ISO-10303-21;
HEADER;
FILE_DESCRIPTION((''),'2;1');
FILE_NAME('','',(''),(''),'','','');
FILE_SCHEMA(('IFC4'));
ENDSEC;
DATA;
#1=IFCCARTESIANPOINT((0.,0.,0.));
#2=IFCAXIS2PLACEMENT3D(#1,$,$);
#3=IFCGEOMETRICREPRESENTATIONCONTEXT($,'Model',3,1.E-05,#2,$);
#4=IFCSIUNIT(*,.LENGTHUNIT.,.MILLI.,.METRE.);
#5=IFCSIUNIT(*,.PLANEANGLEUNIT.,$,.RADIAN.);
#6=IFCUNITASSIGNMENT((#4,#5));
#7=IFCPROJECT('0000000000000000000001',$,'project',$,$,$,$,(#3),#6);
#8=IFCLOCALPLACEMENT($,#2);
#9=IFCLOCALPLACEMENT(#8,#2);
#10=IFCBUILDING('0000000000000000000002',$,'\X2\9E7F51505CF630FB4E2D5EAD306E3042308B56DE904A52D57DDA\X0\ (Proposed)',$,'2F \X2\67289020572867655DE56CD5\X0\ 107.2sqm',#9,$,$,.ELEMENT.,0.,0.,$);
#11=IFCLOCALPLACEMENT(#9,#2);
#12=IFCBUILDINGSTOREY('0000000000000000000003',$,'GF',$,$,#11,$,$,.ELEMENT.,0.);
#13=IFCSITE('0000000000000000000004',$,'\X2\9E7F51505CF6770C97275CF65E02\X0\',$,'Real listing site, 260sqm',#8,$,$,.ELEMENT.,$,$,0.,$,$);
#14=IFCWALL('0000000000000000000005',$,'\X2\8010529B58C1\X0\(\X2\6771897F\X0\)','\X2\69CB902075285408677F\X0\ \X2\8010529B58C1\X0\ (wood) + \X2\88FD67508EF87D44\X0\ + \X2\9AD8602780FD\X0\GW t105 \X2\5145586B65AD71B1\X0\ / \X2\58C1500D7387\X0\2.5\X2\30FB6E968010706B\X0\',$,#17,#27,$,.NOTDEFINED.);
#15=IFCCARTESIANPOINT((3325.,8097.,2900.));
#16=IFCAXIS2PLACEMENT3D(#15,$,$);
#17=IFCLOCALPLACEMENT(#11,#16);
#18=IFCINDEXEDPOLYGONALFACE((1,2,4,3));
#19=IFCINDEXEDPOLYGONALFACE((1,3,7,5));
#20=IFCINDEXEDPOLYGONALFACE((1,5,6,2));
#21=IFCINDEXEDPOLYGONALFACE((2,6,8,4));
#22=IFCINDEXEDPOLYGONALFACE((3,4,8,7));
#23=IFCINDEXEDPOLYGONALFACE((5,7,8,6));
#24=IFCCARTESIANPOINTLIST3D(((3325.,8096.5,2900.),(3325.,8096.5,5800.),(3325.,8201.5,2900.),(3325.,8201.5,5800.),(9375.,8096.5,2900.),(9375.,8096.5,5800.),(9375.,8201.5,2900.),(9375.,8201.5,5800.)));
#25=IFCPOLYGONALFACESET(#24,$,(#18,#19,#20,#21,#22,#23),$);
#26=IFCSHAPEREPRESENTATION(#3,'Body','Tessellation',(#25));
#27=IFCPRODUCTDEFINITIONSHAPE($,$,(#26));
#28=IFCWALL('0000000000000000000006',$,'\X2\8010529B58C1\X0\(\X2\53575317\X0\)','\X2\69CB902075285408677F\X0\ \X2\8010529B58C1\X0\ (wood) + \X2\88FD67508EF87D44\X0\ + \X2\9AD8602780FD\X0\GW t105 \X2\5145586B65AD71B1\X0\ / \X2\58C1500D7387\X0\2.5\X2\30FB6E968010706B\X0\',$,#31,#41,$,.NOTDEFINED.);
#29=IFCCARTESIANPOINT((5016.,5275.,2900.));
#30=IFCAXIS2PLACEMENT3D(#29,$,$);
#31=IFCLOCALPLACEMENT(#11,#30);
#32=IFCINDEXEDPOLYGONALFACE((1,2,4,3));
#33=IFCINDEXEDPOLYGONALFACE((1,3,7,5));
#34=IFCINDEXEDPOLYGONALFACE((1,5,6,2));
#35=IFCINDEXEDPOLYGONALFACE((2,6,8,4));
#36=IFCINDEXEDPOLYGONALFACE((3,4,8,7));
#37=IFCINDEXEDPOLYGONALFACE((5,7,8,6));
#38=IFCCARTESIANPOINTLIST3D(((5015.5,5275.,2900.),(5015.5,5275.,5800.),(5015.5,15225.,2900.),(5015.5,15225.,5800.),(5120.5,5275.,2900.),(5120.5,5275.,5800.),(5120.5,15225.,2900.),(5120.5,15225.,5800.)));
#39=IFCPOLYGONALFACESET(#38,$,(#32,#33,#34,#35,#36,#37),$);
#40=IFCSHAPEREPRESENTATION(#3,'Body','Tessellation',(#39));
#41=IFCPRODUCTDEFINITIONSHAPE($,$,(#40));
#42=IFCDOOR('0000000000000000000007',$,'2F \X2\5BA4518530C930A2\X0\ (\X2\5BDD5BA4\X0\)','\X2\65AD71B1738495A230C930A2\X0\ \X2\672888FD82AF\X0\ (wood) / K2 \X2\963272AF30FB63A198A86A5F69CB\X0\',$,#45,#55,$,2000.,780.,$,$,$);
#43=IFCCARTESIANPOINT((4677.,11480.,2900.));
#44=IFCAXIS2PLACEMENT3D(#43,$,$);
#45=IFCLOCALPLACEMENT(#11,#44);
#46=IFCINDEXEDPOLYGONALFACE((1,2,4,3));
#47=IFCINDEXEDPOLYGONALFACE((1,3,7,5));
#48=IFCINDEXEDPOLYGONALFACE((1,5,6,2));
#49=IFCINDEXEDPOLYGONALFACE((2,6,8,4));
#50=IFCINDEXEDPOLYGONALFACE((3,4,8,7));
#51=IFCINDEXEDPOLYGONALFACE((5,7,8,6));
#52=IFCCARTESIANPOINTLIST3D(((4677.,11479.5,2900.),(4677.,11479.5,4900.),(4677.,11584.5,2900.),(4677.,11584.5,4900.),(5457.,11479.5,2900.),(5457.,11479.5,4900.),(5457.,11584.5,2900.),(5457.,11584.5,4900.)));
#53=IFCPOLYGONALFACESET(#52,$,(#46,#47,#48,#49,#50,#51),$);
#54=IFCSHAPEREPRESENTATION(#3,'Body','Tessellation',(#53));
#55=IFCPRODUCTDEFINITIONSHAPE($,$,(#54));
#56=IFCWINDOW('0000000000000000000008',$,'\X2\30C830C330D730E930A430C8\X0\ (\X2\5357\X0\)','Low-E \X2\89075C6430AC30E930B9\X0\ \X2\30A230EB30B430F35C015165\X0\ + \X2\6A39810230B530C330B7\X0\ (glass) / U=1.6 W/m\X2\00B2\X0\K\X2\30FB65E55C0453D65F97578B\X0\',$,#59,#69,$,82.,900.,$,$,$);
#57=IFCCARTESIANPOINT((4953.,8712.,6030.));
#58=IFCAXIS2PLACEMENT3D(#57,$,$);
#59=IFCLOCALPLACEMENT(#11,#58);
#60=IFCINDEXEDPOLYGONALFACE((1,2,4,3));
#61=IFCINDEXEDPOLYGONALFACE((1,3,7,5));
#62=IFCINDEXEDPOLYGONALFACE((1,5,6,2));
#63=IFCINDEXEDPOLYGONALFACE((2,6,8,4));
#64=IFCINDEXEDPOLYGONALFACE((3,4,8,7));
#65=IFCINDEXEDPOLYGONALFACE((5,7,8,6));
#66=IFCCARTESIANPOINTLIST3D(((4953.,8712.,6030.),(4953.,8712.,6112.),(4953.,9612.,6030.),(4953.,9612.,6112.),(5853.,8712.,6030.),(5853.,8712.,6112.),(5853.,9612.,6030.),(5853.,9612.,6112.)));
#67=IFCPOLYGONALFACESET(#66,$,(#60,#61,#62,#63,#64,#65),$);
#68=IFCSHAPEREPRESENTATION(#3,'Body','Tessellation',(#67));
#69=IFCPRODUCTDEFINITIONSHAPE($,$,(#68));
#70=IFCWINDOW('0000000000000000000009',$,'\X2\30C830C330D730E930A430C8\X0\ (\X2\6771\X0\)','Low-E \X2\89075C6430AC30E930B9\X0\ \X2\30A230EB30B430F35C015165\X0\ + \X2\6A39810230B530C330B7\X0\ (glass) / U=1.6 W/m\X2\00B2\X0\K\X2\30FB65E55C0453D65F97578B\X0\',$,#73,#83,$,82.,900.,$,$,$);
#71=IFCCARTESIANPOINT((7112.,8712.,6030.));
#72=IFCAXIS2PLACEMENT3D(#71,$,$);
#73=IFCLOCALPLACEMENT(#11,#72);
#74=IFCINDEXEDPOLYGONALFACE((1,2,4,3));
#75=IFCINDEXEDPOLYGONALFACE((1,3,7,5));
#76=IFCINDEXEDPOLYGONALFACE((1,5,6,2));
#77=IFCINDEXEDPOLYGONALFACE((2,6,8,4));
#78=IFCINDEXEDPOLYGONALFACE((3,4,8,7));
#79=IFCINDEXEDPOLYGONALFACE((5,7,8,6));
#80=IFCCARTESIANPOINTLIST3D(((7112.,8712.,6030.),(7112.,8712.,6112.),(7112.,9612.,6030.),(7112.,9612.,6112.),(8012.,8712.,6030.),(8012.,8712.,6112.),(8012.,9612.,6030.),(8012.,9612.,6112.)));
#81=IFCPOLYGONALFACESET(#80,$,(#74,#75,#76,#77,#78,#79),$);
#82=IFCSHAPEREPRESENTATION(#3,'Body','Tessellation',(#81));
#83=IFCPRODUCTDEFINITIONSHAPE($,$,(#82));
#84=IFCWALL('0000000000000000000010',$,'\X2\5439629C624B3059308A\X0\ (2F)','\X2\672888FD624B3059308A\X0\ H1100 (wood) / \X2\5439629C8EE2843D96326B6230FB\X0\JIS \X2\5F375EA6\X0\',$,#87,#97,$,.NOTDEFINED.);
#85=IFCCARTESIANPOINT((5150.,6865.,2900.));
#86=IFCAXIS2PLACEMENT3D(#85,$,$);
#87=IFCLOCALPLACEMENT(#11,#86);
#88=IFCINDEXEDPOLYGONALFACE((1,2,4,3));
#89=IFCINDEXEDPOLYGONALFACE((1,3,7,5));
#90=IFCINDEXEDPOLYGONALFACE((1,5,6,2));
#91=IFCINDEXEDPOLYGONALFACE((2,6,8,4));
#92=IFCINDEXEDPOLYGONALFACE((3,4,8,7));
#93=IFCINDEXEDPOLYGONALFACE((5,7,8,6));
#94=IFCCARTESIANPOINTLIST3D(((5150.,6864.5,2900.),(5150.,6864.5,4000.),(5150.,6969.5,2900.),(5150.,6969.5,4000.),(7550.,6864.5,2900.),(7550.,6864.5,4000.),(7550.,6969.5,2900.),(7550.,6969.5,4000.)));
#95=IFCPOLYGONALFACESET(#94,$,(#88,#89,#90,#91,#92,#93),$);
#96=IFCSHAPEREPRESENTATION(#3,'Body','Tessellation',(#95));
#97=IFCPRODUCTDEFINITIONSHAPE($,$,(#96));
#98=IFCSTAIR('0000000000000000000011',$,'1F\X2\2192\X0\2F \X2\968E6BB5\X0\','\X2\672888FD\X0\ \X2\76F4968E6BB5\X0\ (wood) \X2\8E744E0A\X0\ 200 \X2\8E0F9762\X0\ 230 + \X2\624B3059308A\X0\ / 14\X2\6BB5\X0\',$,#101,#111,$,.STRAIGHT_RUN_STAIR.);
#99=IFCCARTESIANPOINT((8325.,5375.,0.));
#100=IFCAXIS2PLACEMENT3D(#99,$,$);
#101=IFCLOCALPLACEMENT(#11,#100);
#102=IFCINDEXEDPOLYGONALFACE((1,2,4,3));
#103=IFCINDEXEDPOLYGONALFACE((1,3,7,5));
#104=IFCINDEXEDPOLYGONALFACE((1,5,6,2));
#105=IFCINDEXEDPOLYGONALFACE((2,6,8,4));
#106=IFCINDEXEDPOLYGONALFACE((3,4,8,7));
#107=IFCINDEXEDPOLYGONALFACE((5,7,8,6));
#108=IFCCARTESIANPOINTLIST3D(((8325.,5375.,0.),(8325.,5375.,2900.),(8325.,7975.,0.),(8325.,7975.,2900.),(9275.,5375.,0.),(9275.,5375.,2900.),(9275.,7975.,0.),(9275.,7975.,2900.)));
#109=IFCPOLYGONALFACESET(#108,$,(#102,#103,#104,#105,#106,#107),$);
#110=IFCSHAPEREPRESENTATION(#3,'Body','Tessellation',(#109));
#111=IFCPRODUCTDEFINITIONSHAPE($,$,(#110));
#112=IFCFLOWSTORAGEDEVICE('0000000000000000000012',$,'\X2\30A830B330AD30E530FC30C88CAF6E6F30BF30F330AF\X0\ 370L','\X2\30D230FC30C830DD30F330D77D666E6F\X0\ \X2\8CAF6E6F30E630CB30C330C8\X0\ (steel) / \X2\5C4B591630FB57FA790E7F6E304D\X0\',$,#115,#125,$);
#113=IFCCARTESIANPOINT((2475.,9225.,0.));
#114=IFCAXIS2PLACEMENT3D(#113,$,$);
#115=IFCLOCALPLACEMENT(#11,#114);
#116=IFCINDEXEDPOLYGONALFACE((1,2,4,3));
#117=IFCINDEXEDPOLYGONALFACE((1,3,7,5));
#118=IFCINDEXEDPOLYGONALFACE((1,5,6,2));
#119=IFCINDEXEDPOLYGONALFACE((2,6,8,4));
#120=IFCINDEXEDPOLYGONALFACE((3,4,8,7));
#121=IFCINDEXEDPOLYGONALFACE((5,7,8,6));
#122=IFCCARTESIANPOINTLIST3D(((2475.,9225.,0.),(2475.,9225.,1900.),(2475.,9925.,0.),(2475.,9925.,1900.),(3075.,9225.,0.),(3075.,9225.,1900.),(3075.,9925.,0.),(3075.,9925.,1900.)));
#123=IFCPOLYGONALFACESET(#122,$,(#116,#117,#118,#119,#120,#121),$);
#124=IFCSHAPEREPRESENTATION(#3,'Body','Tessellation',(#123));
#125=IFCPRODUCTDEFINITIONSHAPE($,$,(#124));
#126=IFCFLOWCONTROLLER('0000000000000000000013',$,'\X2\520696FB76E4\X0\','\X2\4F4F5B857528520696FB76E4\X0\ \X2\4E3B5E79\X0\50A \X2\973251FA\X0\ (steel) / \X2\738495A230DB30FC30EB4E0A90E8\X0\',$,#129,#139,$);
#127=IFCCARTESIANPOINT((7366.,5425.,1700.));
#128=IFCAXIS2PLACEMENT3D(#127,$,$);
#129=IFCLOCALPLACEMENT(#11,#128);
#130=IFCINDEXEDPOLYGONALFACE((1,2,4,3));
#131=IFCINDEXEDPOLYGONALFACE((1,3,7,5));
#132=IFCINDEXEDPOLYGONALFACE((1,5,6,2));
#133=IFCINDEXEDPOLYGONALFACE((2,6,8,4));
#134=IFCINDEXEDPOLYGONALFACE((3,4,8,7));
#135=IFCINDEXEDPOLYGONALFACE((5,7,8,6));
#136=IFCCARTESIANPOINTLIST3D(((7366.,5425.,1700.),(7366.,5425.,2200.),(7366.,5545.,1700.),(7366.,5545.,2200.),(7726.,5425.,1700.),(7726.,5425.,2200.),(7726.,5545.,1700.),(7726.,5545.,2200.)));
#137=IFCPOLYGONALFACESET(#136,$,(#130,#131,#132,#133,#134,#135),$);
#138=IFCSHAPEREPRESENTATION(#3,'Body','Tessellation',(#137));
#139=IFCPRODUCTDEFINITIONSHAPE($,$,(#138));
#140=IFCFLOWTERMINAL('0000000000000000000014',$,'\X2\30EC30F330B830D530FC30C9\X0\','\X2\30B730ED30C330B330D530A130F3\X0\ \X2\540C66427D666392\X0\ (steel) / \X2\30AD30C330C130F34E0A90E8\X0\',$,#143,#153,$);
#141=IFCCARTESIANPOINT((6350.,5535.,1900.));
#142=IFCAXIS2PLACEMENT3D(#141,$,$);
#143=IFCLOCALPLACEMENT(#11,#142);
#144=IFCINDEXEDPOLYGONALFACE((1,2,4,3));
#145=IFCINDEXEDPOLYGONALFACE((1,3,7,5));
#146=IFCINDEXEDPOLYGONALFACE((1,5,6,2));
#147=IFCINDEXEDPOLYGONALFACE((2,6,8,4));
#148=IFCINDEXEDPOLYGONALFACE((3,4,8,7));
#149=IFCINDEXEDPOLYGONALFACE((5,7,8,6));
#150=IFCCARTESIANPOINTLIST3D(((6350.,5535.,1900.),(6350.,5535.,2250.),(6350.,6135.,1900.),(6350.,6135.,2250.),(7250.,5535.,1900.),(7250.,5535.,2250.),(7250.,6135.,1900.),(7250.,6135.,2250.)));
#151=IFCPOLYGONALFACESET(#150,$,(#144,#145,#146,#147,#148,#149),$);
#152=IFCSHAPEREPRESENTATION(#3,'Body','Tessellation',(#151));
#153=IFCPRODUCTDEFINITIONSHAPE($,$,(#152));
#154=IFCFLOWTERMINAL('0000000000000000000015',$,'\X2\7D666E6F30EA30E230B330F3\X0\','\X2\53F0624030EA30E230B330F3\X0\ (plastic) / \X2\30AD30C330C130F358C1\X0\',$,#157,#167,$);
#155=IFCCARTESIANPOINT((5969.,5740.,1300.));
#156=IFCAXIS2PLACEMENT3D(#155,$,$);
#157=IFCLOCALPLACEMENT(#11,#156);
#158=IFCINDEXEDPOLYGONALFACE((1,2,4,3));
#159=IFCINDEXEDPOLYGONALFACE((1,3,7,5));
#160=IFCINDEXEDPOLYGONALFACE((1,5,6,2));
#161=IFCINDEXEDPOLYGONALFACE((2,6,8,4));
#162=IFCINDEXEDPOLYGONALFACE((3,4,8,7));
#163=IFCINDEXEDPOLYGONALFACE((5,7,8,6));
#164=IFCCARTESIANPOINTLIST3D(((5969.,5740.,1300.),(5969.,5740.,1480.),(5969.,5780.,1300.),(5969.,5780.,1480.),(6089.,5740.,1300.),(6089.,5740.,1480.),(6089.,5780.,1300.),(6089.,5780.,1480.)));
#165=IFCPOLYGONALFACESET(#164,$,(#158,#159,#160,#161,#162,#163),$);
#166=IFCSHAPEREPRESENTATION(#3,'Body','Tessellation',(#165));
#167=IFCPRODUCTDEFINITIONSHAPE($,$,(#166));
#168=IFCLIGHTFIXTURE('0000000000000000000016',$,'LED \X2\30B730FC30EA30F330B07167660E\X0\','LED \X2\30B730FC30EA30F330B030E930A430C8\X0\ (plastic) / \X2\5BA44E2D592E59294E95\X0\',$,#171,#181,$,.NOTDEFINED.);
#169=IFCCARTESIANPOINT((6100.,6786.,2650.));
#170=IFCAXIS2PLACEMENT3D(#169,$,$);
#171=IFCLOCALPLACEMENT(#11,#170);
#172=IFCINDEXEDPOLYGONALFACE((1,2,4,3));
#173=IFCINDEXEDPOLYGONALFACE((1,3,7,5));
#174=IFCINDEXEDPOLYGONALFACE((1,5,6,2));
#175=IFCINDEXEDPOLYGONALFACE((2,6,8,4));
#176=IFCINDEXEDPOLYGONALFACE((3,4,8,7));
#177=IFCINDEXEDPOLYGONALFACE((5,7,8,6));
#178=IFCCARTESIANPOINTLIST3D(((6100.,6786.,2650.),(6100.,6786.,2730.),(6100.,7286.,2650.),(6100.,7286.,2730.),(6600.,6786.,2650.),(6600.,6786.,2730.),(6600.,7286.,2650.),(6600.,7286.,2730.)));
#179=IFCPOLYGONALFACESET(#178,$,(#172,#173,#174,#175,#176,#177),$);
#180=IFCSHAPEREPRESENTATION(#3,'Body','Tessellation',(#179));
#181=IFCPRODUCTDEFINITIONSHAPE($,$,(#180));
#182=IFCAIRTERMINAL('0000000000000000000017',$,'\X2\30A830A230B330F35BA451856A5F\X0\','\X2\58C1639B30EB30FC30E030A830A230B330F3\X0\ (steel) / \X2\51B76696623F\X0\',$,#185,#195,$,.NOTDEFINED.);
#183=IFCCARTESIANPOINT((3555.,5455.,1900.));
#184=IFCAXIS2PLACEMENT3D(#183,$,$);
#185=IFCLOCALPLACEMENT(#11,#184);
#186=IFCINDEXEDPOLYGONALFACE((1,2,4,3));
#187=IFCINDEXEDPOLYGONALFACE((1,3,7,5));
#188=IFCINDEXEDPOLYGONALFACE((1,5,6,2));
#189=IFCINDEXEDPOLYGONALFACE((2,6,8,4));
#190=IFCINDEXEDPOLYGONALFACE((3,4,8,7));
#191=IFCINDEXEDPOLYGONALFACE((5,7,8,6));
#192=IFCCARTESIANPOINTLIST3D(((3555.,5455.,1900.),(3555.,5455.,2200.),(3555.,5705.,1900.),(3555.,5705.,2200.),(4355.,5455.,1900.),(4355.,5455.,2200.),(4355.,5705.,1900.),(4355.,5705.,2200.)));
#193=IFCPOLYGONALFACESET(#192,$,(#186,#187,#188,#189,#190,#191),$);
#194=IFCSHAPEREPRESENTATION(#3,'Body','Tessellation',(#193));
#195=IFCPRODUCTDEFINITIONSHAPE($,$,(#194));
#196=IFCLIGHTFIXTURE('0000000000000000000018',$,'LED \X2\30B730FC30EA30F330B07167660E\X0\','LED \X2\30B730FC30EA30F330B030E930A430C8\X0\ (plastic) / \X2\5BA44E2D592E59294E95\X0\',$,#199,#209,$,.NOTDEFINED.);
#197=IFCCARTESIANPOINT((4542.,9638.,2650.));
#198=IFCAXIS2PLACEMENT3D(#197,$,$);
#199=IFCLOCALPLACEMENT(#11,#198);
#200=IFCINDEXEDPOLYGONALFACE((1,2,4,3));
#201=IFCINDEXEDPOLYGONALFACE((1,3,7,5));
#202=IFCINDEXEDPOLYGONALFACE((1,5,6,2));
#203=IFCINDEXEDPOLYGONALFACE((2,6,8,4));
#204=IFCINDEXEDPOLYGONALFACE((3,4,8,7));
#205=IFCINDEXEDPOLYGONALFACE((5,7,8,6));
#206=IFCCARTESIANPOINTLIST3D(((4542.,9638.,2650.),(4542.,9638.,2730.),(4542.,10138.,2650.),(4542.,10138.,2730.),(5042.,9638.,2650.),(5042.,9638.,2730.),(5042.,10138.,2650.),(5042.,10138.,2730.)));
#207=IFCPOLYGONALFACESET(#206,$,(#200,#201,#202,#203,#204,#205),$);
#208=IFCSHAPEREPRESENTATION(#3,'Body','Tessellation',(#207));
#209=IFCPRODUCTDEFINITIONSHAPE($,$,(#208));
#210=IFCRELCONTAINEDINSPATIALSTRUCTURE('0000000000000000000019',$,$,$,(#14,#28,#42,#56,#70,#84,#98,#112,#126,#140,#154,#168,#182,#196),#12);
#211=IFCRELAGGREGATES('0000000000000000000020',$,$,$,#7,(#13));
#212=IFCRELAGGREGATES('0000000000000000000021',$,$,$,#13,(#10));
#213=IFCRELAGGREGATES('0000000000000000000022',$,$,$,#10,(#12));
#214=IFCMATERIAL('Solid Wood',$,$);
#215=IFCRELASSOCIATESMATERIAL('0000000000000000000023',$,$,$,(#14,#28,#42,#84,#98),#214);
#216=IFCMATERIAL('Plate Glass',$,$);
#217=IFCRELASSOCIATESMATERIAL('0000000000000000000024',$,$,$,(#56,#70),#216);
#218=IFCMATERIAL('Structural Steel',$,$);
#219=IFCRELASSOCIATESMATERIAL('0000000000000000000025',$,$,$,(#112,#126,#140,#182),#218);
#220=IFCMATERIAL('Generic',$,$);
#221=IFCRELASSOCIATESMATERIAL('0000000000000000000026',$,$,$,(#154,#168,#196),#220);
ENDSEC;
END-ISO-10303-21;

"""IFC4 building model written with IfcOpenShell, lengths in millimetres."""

from ifc_helpers import new_model, si_unit, frame, frame_2d, origin, place, context, project, spatial, rectangle, extrude, material, element, fill, save


model = new_model("IFC4")

# Units and contexts
model_context = context("Model", 3, precision=1e-05, world=origin())
ifc_project = project(units=[si_unit("LENGTHUNIT", "METRE", prefix="MILLI"), si_unit("PLANEANGLEUNIT", "RADIAN")], contexts=[model_context])

# Site, building, storey
site_placement = place(None, origin())
site = spatial("IfcSite", under=ifc_project, at=site_placement, Name="鹿児島県霧島市", ObjectType="Real listing site, 260sqm", CompositionType="ELEMENT", RefElevation=0.0)
building_placement = place(site_placement, origin())
building = spatial("IfcBuilding", under=site, at=building_placement, Name="鹿児島・中庭のある回遊動線 (Proposed)", ObjectType="2F 木造在来工法 107.2sqm", CompositionType="ELEMENT", ElevationOfRefHeight=0.0, ElevationOfTerrain=0.0)
storey_placement = place(building_placement, origin())
storey = spatial("IfcBuildingStorey", under=building, at=storey_placement, Name="GF", CompositionType="ELEMENT", Elevation=0.0)

# Shared definitions
ifc_material_1 = material(Name="Solid Wood")

# Wall
wall_1_placement = place(storey_placement, frame((3325.0, 8097.0, 2900.0)))
element("IfcWall", 1, at=wall_1_placement, inside=storey, material=ifc_material_1, Name="耐力壁(東西)", Description="構造用合板 耐力壁 (wood) + 製材軸組 + 高性能GW t105 充填断熱 / 壁倍率2.5・準耐火", PredefinedType="NOTDEFINED", context=model_context, shape_type="SweptSolid", body=[
    extrude(rectangle(XDim=6050.0, YDim=105.0, at=frame_2d((3025.0, 52.0))), frame((3325.0, 8097.0, 2900.0)), (0.0, 0.0, 1.0), 2900.0),
])

# Wall, opening, door
wall_2_placement = place(storey_placement, frame((5016.0, 5275.0, 2900.0)))
wall_2 = element("IfcWall", 2, at=wall_2_placement, inside=storey, material=ifc_material_1, Name="耐力壁(南北)", Description="構造用合板 耐力壁 (wood) + 製材軸組 + 高性能GW t105 充填断熱 / 壁倍率2.5・準耐火", PredefinedType="NOTDEFINED", context=model_context, shape_type="SweptSolid", body=[
    extrude(rectangle(XDim=105.0, YDim=9950.0, at=frame_2d((52.0, 4975.0))), frame((5016.0, 5275.0, 2900.0)), (0.0, 0.0, 1.0), 2900.0),
])
opening_placement = place(storey_placement, frame((4677.0, 11480.0, 2900.0)))
opening = element("IfcOpeningElement", 3, at=opening_placement, cuts=wall_2, PredefinedType="NOTDEFINED", context=model_context, shape_type="SweptSolid", body=[
    extrude(rectangle(XDim=780.0, YDim=105.0, at=frame_2d((390.0, 52.0))), frame((4677.0, 11480.0, 2900.0)), (0.0, 0.0, 1.0), 2000.0),
])
door_placement = place(storey_placement, frame((4677.0, 11480.0, 2900.0)))
door = element("IfcDoor", 4, at=door_placement, inside=storey, material=ifc_material_1, Name="2F 室内ドア (寝室)", Description="断熱玄関ドア 木製芯 (wood) / K2 防犯・採風機構", OverallHeight=2000.0, OverallWidth=780.0, context=model_context, shape_type="SweptSolid", body=[
    extrude(rectangle(XDim=780.0, YDim=105.0, at=frame_2d((390.0, 52.0))), frame((4677.0, 11480.0, 2900.0)), (0.0, 0.0, 1.0), 2000.0),
])
fill(opening, door)

# Windows
ifc_material_2 = material(Name="Plate Glass")
window_1_placement = place(storey_placement, frame((4953.0, 8712.0, 6030.0)))
element("IfcWindow", 5, at=window_1_placement, inside=storey, material=ifc_material_2, Name="トップライト (南)", Description="Low-E 複層ガラス アルゴン封入 + 樹脂サッシ (glass) / U=1.6 W/m²K・日射取得型", OverallHeight=82.0, OverallWidth=900.0, context=model_context, shape_type="SweptSolid", body=[
    extrude(rectangle(XDim=900.0, YDim=900.0, at=frame_2d((450.0, 450.0))), frame((4953.0, 8712.0, 6030.0)), (0.0, 0.0, 1.0), 82.0),
])
window_2_placement = place(storey_placement, frame((7112.0, 8712.0, 6030.0)))
element("IfcWindow", 6, at=window_2_placement, inside=storey, material=ifc_material_2, Name="トップライト (東)", Description="Low-E 複層ガラス アルゴン封入 + 樹脂サッシ (glass) / U=1.6 W/m²K・日射取得型", OverallHeight=82.0, OverallWidth=900.0, context=model_context, shape_type="SweptSolid", body=[
    extrude(rectangle(XDim=900.0, YDim=900.0, at=frame_2d((450.0, 450.0))), frame((7112.0, 8712.0, 6030.0)), (0.0, 0.0, 1.0), 82.0),
])

# Wall
wall_3_placement = place(storey_placement, frame((5150.0, 6865.0, 2900.0)))
element("IfcWall", 7, at=wall_3_placement, inside=storey, material=ifc_material_1, Name="吹抜手すり (2F)", Description="木製手すり H1100 (wood) / 吹抜転落防止・JIS 強度", PredefinedType="NOTDEFINED", context=model_context, shape_type="SweptSolid", body=[
    extrude(rectangle(XDim=2400.0, YDim=105.0, at=frame_2d((1200.0, 52.0))), frame((5150.0, 6865.0, 2900.0)), (0.0, 0.0, 1.0), 1100.0),
])

# Stair
stair_placement = place(storey_placement, frame((8325.0, 5375.0, 0.0)))
element("IfcStair", 8, at=stair_placement, inside=storey, material=ifc_material_1, Name="1F→2F 階段", Description="木製 直階段 (wood) 蹴上 200 踏面 230 + 手すり / 14段", PredefinedType="STRAIGHT_RUN_STAIR", context=model_context, shape_type="SweptSolid", body=[
    extrude(rectangle(XDim=950.0, YDim=2600.0, at=frame_2d((475.0, 1300.0))), frame((8325.0, 5375.0, 0.0)), (0.0, 0.0, 1.0), 2900.0),
])

# Flow storage device
ifc_material_3 = material(Name="Structural Steel")
flow_storage_device_placement = place(storey_placement, frame((2475.0, 9225.0, 0.0)))
element("IfcFlowStorageDevice", 9, at=flow_storage_device_placement, inside=storey, material=ifc_material_3, Name="エコキュート貯湯タンク 370L", Description="ヒートポンプ給湯 貯湯ユニット (steel) / 屋外・基礎置き", context=model_context, shape_type="SweptSolid", body=[
    extrude(rectangle(XDim=600.0, YDim=700.0, at=frame_2d((300.0, 350.0))), frame((2475.0, 9225.0, 0.0)), (0.0, 0.0, 1.0), 1900.0),
])

# Flow controller
flow_controller_placement = place(storey_placement, frame((7366.0, 5425.0, 1700.0)))
element("IfcFlowController", 10, at=flow_controller_placement, inside=storey, material=ifc_material_3, Name="分電盤", Description="住宅用分電盤 主幹50A 露出 (steel) / 玄関ホール上部", context=model_context, shape_type="SweptSolid", body=[
    extrude(rectangle(XDim=360.0, YDim=120.0, at=frame_2d((180.0, 60.0))), frame((7366.0, 5425.0, 1700.0)), (0.0, 0.0, 1.0), 500.0),
])

# Flow terminals
flow_terminal_1_placement = place(storey_placement, frame((6350.0, 5535.0, 1900.0)))
element("IfcFlowTerminal", 11, at=flow_terminal_1_placement, inside=storey, material=ifc_material_3, Name="レンジフード", Description="シロッコファン 同時給排 (steel) / キッチン上部", context=model_context, shape_type="SweptSolid", body=[
    extrude(rectangle(XDim=900.0, YDim=600.0, at=frame_2d((450.0, 300.0))), frame((6350.0, 5535.0, 1900.0)), (0.0, 0.0, 1.0), 350.0),
])
ifc_material_4 = material(Name="Generic")
flow_terminal_2_placement = place(storey_placement, frame((5969.0, 5740.0, 1300.0)))
element("IfcFlowTerminal", 12, at=flow_terminal_2_placement, inside=storey, material=ifc_material_4, Name="給湯リモコン", Description="台所リモコン (plastic) / キッチン壁", context=model_context, shape_type="SweptSolid", body=[
    extrude(rectangle(XDim=120.0, YDim=40.0, at=frame_2d((60.0, 20.0))), frame((5969.0, 5740.0, 1300.0)), (0.0, 0.0, 1.0), 180.0),
])

# Light fixture
light_fixture_1_placement = place(storey_placement, frame((6100.0, 6786.0, 2650.0)))
element("IfcLightFixture", 13, at=light_fixture_1_placement, inside=storey, material=ifc_material_4, Name="LED シーリング照明", Description="LED シーリングライト (plastic) / 室中央天井", PredefinedType="NOTDEFINED", context=model_context, shape_type="SweptSolid", body=[
    extrude(rectangle(XDim=500.0, YDim=500.0, at=frame_2d((250.0, 250.0))), frame((6100.0, 6786.0, 2650.0)), (0.0, 0.0, 1.0), 80.0),
])

# Air terminal
air_terminal_1_placement = place(storey_placement, frame((3555.0, 5455.0, 1900.0)))
element("IfcAirTerminal", 14, at=air_terminal_1_placement, inside=storey, material=ifc_material_3, Name="エアコン室内機", Description="壁掛ルームエアコン (steel) / 冷暖房", PredefinedType="NOTDEFINED", context=model_context, shape_type="SweptSolid", body=[
    extrude(rectangle(XDim=800.0, YDim=250.0, at=frame_2d((400.0, 125.0))), frame((3555.0, 5455.0, 1900.0)), (0.0, 0.0, 1.0), 300.0),
])

# Light fixture
light_fixture_2_placement = place(storey_placement, frame((4542.0, 9638.0, 2650.0)))
element("IfcLightFixture", 15, at=light_fixture_2_placement, inside=storey, material=ifc_material_4, Name="LED シーリング照明", Description="LED シーリングライト (plastic) / 室中央天井", PredefinedType="NOTDEFINED", context=model_context, shape_type="SweptSolid", body=[
    extrude(rectangle(XDim=500.0, YDim=500.0, at=frame_2d((250.0, 250.0))), frame((4542.0, 9638.0, 2650.0)), (0.0, 0.0, 1.0), 80.0),
])

save(model, "model.ifc")
